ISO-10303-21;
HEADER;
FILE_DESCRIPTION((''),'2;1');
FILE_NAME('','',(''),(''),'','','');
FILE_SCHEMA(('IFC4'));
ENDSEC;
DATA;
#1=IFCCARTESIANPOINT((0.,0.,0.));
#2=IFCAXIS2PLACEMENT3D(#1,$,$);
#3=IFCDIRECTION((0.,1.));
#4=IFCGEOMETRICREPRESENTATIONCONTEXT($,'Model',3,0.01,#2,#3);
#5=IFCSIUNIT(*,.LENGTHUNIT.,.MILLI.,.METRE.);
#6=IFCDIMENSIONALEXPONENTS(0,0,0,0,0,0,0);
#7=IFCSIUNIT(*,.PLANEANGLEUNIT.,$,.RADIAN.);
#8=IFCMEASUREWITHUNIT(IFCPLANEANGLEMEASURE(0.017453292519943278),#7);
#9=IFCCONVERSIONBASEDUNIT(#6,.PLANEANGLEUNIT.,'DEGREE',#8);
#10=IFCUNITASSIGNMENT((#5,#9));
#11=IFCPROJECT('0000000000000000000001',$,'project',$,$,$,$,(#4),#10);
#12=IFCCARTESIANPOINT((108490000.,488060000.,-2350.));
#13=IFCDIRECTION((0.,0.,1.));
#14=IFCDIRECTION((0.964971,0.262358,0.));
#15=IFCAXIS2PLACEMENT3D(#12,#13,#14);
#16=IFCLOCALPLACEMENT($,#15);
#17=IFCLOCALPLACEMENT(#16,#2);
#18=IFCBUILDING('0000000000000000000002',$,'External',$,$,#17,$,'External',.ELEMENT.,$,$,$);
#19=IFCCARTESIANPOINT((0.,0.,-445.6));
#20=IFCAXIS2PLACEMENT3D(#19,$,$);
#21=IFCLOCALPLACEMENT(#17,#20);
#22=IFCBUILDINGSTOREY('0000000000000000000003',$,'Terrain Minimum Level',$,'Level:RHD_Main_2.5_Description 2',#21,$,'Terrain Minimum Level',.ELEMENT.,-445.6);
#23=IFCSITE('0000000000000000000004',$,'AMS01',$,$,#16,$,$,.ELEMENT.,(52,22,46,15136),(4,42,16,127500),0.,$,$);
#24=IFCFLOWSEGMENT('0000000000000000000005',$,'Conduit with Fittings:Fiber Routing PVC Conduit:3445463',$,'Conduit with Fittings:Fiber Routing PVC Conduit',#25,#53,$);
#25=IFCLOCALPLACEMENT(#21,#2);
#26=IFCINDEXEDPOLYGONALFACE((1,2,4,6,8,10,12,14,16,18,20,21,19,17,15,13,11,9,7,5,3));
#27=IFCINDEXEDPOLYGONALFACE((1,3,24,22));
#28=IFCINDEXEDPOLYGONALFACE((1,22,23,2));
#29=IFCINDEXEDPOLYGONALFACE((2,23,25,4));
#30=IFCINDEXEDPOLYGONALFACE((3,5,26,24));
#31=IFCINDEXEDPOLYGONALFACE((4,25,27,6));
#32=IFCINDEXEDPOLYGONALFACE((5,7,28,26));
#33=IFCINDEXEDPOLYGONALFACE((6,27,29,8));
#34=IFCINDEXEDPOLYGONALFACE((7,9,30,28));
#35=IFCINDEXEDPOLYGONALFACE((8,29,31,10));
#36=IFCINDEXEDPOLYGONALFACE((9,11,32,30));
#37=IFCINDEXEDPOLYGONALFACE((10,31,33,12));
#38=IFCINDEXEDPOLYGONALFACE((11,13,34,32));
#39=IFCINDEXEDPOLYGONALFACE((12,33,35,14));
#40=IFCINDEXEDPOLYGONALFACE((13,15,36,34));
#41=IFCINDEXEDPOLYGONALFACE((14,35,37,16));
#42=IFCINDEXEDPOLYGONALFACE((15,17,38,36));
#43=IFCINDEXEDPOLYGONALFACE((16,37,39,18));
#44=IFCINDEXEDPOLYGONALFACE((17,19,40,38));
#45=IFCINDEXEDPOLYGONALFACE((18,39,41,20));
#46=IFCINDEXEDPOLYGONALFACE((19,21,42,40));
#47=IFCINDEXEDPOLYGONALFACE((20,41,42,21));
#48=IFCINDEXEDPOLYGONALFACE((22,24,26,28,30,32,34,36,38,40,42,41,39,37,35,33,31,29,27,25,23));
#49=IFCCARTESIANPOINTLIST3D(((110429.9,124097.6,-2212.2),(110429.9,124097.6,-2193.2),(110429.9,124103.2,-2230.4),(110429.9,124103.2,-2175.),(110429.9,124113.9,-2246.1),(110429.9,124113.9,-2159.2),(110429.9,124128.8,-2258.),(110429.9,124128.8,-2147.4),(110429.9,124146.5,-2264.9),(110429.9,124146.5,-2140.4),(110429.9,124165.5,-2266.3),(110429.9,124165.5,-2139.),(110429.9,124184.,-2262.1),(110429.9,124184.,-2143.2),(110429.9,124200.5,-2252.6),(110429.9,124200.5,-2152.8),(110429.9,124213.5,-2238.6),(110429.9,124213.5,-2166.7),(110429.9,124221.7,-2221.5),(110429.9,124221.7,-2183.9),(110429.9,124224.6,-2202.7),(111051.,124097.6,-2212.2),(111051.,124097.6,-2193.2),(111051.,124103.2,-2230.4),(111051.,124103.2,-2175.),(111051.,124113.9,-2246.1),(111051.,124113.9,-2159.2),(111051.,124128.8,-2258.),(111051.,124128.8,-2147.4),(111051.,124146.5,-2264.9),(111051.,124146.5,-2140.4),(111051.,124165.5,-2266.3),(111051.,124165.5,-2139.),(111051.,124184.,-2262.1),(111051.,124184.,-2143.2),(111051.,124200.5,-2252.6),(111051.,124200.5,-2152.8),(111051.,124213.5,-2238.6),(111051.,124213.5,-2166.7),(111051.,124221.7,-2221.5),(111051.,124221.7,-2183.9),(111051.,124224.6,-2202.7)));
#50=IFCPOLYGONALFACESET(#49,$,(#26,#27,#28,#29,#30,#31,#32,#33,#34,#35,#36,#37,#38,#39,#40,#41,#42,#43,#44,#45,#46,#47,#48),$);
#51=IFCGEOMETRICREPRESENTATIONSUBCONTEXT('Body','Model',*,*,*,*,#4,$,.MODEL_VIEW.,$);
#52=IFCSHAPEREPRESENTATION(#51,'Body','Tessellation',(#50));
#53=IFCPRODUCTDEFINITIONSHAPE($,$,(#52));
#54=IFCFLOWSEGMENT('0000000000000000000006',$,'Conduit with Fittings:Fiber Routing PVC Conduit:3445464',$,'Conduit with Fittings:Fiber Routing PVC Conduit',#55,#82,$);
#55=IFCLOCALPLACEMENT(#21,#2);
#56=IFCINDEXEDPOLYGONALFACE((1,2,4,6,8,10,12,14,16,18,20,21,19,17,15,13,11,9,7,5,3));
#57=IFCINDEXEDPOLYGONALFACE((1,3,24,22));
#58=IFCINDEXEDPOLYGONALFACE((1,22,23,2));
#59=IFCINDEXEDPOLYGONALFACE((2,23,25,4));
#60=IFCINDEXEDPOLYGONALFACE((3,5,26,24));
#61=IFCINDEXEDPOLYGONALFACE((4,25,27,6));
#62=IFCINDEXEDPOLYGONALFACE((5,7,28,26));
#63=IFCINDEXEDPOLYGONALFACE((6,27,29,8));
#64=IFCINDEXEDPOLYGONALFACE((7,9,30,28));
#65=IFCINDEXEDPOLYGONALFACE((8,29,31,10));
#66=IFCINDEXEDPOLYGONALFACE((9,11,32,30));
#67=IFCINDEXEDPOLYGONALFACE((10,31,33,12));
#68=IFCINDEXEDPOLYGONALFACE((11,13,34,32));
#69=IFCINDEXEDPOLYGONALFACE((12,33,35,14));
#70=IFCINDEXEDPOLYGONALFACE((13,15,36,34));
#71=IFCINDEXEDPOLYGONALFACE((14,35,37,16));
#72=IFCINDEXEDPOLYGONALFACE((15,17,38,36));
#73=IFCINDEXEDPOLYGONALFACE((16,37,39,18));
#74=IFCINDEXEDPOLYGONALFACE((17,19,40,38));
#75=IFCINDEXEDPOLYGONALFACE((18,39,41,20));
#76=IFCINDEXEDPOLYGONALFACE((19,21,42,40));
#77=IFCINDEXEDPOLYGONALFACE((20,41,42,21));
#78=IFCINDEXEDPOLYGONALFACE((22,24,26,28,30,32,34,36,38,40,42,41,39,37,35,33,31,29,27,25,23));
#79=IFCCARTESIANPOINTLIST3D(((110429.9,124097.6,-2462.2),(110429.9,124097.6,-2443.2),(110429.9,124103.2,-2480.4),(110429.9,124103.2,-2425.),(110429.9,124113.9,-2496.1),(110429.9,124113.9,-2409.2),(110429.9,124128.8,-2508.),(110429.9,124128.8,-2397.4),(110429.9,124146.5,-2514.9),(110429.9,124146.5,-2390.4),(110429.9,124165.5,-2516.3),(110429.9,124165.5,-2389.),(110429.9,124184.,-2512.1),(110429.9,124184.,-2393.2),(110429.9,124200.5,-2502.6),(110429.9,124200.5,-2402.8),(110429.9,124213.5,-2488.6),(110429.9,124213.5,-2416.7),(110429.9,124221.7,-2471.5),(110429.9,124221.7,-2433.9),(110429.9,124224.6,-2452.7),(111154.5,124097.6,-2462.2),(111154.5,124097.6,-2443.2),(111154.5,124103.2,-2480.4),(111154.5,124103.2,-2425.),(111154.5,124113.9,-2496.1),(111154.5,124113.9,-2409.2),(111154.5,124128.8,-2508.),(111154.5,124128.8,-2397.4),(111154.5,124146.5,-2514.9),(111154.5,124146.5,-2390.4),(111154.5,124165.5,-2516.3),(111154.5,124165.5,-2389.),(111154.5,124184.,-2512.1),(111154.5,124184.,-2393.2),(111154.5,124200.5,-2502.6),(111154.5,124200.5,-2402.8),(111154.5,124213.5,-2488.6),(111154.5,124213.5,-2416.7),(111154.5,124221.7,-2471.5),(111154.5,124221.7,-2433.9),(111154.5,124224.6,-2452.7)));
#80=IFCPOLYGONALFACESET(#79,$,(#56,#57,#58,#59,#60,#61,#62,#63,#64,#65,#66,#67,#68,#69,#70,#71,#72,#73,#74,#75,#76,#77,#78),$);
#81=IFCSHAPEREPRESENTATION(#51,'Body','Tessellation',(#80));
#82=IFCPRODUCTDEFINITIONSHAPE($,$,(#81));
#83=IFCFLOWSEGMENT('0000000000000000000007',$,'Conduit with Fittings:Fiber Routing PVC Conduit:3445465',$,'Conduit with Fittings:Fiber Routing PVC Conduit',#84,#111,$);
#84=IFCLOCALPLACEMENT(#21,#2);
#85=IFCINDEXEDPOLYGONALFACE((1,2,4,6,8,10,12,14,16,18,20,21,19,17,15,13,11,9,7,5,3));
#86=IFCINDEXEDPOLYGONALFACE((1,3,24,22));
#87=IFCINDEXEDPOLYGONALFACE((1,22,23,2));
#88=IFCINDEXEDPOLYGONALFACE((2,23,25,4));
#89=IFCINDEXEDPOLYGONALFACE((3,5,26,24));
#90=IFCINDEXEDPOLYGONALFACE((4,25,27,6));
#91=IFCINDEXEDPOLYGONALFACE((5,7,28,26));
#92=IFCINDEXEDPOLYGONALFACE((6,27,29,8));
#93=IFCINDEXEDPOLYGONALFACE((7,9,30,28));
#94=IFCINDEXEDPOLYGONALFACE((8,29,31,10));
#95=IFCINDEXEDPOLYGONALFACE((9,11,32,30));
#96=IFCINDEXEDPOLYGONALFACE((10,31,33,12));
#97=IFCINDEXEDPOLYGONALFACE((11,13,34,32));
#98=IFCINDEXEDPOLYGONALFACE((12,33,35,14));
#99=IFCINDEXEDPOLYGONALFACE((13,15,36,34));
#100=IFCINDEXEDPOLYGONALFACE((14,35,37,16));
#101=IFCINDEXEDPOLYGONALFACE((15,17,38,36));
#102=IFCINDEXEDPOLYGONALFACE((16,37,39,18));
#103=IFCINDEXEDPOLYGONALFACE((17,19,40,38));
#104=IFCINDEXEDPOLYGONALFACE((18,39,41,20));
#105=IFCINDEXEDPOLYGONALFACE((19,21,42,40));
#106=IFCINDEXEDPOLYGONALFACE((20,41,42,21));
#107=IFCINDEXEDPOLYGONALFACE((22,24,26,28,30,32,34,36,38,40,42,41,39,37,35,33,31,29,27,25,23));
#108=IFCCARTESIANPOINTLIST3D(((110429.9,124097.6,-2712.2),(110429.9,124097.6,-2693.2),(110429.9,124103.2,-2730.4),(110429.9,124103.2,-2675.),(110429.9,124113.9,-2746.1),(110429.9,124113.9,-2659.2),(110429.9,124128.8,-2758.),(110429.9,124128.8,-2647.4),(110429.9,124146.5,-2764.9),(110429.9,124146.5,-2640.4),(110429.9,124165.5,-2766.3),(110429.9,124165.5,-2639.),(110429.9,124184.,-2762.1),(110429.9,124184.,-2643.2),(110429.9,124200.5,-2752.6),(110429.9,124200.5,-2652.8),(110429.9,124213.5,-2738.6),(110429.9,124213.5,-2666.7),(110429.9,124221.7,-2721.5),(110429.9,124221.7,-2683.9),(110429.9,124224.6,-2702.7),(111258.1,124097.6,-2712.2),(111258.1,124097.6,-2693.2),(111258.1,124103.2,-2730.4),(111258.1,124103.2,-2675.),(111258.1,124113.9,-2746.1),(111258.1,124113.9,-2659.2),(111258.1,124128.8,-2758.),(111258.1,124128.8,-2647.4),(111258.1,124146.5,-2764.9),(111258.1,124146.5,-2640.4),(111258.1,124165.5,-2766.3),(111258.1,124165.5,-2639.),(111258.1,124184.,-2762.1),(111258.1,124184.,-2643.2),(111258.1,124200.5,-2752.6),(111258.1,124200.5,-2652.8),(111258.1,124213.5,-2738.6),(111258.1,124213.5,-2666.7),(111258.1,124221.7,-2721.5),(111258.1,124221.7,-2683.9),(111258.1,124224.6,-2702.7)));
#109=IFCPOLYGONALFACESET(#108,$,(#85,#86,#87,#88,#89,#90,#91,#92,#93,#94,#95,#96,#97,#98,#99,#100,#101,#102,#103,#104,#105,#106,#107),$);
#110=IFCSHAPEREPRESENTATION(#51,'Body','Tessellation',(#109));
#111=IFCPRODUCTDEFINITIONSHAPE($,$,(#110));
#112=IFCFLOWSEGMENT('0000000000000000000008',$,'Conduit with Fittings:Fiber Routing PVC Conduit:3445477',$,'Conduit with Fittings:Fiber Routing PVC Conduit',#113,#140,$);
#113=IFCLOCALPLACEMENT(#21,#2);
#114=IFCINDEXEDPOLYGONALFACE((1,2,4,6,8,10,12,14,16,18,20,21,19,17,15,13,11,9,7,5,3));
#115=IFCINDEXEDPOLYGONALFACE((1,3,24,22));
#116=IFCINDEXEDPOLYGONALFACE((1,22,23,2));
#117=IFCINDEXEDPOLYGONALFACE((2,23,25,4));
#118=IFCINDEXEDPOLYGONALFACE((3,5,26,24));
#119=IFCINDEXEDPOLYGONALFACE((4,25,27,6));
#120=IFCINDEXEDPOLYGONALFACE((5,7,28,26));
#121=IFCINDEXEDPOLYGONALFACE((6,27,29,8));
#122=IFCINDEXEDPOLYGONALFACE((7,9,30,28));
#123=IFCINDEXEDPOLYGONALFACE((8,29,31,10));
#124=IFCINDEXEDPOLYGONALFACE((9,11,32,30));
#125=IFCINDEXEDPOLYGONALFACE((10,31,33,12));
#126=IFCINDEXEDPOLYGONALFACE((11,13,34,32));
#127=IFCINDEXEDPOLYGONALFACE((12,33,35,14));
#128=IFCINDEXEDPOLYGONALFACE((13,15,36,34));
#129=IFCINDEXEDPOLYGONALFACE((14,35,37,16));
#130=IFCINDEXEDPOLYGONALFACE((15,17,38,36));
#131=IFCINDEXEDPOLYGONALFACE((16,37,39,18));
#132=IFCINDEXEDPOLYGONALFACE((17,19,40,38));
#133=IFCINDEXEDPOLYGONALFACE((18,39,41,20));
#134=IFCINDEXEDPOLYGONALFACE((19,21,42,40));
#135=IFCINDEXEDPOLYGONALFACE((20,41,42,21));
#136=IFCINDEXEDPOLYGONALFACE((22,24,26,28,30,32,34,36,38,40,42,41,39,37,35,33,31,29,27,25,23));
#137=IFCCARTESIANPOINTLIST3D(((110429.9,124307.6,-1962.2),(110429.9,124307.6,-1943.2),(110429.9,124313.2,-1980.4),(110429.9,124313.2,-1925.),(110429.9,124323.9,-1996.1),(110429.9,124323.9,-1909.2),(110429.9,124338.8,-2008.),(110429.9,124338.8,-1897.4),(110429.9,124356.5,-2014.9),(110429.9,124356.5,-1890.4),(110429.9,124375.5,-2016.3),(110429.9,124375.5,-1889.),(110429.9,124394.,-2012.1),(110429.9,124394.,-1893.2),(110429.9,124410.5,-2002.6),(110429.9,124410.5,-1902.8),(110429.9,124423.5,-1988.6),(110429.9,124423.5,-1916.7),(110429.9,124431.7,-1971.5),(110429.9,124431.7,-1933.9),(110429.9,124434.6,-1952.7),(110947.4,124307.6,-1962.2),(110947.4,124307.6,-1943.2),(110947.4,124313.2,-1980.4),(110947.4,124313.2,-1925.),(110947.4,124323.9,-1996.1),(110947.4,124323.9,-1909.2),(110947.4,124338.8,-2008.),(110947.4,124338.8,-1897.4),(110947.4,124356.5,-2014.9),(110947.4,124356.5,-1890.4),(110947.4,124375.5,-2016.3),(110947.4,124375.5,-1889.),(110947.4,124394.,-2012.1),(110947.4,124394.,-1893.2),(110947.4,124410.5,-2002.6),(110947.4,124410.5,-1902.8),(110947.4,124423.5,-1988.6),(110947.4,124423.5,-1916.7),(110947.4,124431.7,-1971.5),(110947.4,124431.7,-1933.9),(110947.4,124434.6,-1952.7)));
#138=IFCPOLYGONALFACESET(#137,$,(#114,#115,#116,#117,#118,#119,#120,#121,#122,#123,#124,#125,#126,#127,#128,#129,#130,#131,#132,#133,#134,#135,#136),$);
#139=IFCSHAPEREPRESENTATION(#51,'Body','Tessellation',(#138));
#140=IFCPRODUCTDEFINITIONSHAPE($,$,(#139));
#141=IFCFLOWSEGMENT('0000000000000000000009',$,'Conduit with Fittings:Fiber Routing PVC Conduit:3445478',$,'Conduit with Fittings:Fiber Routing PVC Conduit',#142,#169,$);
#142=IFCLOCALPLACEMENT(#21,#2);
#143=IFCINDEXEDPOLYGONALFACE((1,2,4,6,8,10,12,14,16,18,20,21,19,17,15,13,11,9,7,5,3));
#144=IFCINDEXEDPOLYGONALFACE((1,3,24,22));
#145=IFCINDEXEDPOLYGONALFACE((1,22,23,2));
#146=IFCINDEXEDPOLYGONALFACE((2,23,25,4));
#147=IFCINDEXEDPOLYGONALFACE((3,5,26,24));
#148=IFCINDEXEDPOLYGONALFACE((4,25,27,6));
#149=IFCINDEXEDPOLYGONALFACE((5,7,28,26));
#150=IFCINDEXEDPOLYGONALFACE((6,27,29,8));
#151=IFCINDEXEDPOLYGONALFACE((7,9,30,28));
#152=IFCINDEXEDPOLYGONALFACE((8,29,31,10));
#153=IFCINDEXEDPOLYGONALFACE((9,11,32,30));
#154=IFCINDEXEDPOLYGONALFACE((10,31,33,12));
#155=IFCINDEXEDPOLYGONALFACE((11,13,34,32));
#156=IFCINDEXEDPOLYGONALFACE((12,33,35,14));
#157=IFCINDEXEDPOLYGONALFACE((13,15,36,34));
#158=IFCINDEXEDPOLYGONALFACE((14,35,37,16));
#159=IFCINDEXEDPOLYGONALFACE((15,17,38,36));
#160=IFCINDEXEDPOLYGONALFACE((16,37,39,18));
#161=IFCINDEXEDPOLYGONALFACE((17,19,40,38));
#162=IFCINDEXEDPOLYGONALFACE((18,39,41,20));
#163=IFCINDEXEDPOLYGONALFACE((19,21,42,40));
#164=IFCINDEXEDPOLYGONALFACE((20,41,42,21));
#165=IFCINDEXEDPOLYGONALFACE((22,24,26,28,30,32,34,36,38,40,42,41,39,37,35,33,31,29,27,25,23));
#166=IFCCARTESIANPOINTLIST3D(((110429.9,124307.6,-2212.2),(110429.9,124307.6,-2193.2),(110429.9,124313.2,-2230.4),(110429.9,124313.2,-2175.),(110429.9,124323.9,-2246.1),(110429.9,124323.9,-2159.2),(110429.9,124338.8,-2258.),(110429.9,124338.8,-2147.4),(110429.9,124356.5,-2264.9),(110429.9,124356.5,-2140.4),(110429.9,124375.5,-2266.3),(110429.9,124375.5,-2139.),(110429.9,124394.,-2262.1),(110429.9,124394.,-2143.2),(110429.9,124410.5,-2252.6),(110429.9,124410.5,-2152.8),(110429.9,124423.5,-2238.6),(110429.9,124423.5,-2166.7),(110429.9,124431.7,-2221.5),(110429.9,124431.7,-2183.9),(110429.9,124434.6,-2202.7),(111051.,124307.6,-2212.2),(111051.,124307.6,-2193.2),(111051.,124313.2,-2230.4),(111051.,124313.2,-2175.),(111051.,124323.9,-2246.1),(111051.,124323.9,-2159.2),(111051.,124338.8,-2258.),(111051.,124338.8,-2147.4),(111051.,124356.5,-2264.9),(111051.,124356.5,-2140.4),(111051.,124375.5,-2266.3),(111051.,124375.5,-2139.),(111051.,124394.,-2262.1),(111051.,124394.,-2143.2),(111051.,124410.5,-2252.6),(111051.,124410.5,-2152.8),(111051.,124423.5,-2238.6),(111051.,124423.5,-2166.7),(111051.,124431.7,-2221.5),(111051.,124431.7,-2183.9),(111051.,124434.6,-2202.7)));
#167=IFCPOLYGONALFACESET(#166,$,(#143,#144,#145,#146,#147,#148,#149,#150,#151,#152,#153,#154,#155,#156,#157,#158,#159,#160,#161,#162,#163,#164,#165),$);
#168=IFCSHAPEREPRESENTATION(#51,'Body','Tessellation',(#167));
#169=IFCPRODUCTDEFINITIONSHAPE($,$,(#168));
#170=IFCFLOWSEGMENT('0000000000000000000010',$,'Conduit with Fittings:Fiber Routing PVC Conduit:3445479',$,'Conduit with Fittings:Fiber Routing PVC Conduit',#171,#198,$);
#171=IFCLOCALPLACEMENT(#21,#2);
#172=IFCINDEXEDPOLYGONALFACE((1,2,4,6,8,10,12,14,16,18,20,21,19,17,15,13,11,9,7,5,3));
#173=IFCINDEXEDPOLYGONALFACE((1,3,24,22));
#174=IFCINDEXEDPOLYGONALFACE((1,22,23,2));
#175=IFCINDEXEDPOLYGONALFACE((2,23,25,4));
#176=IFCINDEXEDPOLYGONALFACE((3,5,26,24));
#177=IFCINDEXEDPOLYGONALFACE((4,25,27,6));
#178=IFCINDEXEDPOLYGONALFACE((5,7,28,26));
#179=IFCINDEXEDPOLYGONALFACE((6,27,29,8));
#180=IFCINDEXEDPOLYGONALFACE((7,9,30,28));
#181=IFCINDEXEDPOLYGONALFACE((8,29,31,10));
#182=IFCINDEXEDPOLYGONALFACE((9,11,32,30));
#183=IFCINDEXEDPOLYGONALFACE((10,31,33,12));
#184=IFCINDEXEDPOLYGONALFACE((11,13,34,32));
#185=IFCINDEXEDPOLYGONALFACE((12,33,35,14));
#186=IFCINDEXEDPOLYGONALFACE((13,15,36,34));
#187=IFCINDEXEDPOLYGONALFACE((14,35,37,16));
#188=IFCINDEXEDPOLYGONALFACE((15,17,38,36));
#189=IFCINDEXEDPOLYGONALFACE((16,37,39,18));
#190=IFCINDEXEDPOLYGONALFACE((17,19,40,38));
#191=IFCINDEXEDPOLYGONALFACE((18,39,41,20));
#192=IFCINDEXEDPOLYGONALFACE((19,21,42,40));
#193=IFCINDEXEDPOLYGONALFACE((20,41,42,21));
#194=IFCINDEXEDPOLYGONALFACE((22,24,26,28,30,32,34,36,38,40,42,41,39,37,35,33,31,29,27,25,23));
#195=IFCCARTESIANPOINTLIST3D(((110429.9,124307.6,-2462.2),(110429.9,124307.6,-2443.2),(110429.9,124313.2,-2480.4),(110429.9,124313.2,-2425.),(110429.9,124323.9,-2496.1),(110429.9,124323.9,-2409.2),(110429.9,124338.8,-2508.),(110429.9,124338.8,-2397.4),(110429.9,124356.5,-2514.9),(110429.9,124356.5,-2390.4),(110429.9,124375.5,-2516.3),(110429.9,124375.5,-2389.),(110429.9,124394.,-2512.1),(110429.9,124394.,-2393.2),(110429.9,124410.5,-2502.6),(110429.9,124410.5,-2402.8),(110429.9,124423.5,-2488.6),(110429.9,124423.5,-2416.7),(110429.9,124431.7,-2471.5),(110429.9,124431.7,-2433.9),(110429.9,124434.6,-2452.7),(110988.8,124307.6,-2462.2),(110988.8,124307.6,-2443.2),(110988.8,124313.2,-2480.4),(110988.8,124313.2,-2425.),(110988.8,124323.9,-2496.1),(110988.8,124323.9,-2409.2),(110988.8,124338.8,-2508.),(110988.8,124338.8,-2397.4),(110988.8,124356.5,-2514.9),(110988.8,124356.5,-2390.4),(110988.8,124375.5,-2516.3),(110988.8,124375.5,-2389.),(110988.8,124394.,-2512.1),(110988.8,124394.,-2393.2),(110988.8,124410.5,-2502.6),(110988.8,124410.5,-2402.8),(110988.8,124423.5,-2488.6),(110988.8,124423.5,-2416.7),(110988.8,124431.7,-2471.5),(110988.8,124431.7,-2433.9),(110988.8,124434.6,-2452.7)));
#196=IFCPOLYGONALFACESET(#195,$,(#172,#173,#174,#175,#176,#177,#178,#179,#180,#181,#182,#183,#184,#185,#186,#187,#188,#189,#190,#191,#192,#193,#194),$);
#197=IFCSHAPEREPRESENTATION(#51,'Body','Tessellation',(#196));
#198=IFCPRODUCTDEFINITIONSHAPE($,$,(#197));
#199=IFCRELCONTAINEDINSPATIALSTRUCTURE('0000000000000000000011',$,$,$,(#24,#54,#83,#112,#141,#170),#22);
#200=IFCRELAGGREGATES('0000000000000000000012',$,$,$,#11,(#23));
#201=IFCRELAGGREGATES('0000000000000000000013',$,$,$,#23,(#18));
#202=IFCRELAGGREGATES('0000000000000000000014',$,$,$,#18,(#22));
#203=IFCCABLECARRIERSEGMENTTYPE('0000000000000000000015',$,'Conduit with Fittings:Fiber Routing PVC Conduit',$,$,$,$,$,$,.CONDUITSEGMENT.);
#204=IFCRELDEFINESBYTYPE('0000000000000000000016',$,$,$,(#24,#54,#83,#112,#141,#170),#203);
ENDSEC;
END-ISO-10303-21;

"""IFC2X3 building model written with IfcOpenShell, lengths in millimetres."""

from ifc_helpers import new_model, entity, si_unit, converted_unit, direction, frame, frame_2d, origin, place, context, subcontext, project, spatial, circle, extrude, type_object, element, save


model = new_model("IFC2X3")

# Units and contexts
model_context = context("Model", 3, precision=0.01, world=origin(), true_north=direction((0.0, 1.0)))
body_context = subcontext(model_context, "Body", "Model", "MODEL_VIEW")
ifc_project = project(units=[si_unit("LENGTHUNIT", "METRE", prefix="MILLI"), converted_unit("PLANEANGLEUNIT", "DEGREE", entity("IfcPlaneAngleMeasure", 0.017453292519943278), si_unit("PLANEANGLEUNIT", "RADIAN"), dimensions=[0, 0, 0, 0, 0, 0, 0])], contexts=[model_context])

# Site, building, storey
site_placement = place(None, frame((108490000.0, 488060000.0, -2350.0), z_axis=(0.0, 0.0, 1.0), x_axis=(0.964971, 0.262358, 0.0)))
site = spatial("IfcSite", under=ifc_project, at=site_placement, Name="AMS01", CompositionType="ELEMENT", RefLatitude=(52, 22, 46, 15136), RefLongitude=(4, 42, 16, 127500), RefElevation=0.0)
building_placement = place(site_placement, origin())
building = spatial("IfcBuilding", under=site, at=building_placement, Name="External", LongName="External", CompositionType="ELEMENT")
storey_placement = place(building_placement, frame((0.0, 0.0, -445.6)))
storey = spatial("IfcBuildingStorey", under=building, at=storey_placement, Name="Terrain Minimum Level", ObjectType="Level:RHD_Main_2.5_Description 2", LongName="Terrain Minimum Level", CompositionType="ELEMENT", Elevation=-445.6)

# Flow segments
cable_carrier_segment_type = type_object("IfcCableCarrierSegmentType", Name="Conduit with Fittings:Fiber Routing PVC Conduit", PredefinedType="CONDUITSEGMENT")
flow_segment_1_placement = place(storey_placement, origin())
element("IfcFlowSegment", 1, at=flow_segment_1_placement, inside=storey, type_object=cable_carrier_segment_type, Name="Conduit with Fittings:Fiber Routing PVC Conduit:3445463", ObjectType="Conduit with Fittings:Fiber Routing PVC Conduit", context=body_context, shape_type="SweptSolid", body=[
    extrude(circle(Radius=63.9, at=frame_2d((0.0, 0.0), x_axis=(1.0, 0.0))), frame((110429.9, 124160.7, -2202.7), z_axis=(1.0, 0.0, 0.0), x_axis=(0.0, 1.0, 0.0)), (0.0, 0.0, 1.0), 621.1),
])
flow_segment_2_placement = place(storey_placement, origin())
element("IfcFlowSegment", 2, at=flow_segment_2_placement, inside=storey, type_object=cable_carrier_segment_type, Name="Conduit with Fittings:Fiber Routing PVC Conduit:3445464", ObjectType="Conduit with Fittings:Fiber Routing PVC Conduit", context=body_context, shape_type="SweptSolid", body=[
    extrude(circle(Radius=63.9, at=frame_2d((0.0, 0.0), x_axis=(1.0, 0.0))), frame((110429.9, 124160.7, -2452.7), z_axis=(1.0, 0.0, 0.0), x_axis=(0.0, 1.0, 0.0)), (0.0, 0.0, 1.0), 724.6),
])
flow_segment_3_placement = place(storey_placement, origin())
element("IfcFlowSegment", 3, at=flow_segment_3_placement, inside=storey, type_object=cable_carrier_segment_type, Name="Conduit with Fittings:Fiber Routing PVC Conduit:3445465", ObjectType="Conduit with Fittings:Fiber Routing PVC Conduit", context=body_context, shape_type="SweptSolid", body=[
    extrude(circle(Radius=63.9, at=frame_2d((0.0, 0.0), x_axis=(1.0, 0.0))), frame((110429.9, 124160.7, -2702.7), z_axis=(1.0, 0.0, 0.0), x_axis=(0.0, 1.0, 0.0)), (0.0, 0.0, 1.0), 828.2),
])
flow_segment_4_placement = place(storey_placement, origin())
element("IfcFlowSegment", 4, at=flow_segment_4_placement, inside=storey, type_object=cable_carrier_segment_type, Name="Conduit with Fittings:Fiber Routing PVC Conduit:3445477", ObjectType="Conduit with Fittings:Fiber Routing PVC Conduit", context=body_context, shape_type="SweptSolid", body=[
    extrude(circle(Radius=63.9, at=frame_2d((0.0, 0.0), x_axis=(1.0, 0.0))), frame((110429.9, 124370.7, -1952.7), z_axis=(1.0, 0.0, 0.0), x_axis=(0.0, 1.0, 0.0)), (0.0, 0.0, 1.0), 517.5),
])
flow_segment_5_placement = place(storey_placement, origin())
element("IfcFlowSegment", 5, at=flow_segment_5_placement, inside=storey, type_object=cable_carrier_segment_type, Name="Conduit with Fittings:Fiber Routing PVC Conduit:3445478", ObjectType="Conduit with Fittings:Fiber Routing PVC Conduit", context=body_context, shape_type="SweptSolid", body=[
    extrude(circle(Radius=63.9, at=frame_2d((0.0, 0.0), x_axis=(1.0, 0.0))), frame((110429.9, 124370.7, -2202.7), z_axis=(1.0, 0.0, 0.0), x_axis=(0.0, 1.0, 0.0)), (0.0, 0.0, 1.0), 621.1),
])
flow_segment_6_placement = place(storey_placement, origin())
element("IfcFlowSegment", 6, at=flow_segment_6_placement, inside=storey, type_object=cable_carrier_segment_type, Name="Conduit with Fittings:Fiber Routing PVC Conduit:3445479", ObjectType="Conduit with Fittings:Fiber Routing PVC Conduit", context=body_context, shape_type="SweptSolid", body=[
    extrude(circle(Radius=63.9, at=frame_2d((0.0, 0.0), x_axis=(1.0, 0.0))), frame((110429.9, 124370.7, -2452.7), z_axis=(1.0, 0.0, 0.0), x_axis=(0.0, 1.0, 0.0)), (0.0, 0.0, 1.0), 559.0),
])

save(model, "model.ifc")
